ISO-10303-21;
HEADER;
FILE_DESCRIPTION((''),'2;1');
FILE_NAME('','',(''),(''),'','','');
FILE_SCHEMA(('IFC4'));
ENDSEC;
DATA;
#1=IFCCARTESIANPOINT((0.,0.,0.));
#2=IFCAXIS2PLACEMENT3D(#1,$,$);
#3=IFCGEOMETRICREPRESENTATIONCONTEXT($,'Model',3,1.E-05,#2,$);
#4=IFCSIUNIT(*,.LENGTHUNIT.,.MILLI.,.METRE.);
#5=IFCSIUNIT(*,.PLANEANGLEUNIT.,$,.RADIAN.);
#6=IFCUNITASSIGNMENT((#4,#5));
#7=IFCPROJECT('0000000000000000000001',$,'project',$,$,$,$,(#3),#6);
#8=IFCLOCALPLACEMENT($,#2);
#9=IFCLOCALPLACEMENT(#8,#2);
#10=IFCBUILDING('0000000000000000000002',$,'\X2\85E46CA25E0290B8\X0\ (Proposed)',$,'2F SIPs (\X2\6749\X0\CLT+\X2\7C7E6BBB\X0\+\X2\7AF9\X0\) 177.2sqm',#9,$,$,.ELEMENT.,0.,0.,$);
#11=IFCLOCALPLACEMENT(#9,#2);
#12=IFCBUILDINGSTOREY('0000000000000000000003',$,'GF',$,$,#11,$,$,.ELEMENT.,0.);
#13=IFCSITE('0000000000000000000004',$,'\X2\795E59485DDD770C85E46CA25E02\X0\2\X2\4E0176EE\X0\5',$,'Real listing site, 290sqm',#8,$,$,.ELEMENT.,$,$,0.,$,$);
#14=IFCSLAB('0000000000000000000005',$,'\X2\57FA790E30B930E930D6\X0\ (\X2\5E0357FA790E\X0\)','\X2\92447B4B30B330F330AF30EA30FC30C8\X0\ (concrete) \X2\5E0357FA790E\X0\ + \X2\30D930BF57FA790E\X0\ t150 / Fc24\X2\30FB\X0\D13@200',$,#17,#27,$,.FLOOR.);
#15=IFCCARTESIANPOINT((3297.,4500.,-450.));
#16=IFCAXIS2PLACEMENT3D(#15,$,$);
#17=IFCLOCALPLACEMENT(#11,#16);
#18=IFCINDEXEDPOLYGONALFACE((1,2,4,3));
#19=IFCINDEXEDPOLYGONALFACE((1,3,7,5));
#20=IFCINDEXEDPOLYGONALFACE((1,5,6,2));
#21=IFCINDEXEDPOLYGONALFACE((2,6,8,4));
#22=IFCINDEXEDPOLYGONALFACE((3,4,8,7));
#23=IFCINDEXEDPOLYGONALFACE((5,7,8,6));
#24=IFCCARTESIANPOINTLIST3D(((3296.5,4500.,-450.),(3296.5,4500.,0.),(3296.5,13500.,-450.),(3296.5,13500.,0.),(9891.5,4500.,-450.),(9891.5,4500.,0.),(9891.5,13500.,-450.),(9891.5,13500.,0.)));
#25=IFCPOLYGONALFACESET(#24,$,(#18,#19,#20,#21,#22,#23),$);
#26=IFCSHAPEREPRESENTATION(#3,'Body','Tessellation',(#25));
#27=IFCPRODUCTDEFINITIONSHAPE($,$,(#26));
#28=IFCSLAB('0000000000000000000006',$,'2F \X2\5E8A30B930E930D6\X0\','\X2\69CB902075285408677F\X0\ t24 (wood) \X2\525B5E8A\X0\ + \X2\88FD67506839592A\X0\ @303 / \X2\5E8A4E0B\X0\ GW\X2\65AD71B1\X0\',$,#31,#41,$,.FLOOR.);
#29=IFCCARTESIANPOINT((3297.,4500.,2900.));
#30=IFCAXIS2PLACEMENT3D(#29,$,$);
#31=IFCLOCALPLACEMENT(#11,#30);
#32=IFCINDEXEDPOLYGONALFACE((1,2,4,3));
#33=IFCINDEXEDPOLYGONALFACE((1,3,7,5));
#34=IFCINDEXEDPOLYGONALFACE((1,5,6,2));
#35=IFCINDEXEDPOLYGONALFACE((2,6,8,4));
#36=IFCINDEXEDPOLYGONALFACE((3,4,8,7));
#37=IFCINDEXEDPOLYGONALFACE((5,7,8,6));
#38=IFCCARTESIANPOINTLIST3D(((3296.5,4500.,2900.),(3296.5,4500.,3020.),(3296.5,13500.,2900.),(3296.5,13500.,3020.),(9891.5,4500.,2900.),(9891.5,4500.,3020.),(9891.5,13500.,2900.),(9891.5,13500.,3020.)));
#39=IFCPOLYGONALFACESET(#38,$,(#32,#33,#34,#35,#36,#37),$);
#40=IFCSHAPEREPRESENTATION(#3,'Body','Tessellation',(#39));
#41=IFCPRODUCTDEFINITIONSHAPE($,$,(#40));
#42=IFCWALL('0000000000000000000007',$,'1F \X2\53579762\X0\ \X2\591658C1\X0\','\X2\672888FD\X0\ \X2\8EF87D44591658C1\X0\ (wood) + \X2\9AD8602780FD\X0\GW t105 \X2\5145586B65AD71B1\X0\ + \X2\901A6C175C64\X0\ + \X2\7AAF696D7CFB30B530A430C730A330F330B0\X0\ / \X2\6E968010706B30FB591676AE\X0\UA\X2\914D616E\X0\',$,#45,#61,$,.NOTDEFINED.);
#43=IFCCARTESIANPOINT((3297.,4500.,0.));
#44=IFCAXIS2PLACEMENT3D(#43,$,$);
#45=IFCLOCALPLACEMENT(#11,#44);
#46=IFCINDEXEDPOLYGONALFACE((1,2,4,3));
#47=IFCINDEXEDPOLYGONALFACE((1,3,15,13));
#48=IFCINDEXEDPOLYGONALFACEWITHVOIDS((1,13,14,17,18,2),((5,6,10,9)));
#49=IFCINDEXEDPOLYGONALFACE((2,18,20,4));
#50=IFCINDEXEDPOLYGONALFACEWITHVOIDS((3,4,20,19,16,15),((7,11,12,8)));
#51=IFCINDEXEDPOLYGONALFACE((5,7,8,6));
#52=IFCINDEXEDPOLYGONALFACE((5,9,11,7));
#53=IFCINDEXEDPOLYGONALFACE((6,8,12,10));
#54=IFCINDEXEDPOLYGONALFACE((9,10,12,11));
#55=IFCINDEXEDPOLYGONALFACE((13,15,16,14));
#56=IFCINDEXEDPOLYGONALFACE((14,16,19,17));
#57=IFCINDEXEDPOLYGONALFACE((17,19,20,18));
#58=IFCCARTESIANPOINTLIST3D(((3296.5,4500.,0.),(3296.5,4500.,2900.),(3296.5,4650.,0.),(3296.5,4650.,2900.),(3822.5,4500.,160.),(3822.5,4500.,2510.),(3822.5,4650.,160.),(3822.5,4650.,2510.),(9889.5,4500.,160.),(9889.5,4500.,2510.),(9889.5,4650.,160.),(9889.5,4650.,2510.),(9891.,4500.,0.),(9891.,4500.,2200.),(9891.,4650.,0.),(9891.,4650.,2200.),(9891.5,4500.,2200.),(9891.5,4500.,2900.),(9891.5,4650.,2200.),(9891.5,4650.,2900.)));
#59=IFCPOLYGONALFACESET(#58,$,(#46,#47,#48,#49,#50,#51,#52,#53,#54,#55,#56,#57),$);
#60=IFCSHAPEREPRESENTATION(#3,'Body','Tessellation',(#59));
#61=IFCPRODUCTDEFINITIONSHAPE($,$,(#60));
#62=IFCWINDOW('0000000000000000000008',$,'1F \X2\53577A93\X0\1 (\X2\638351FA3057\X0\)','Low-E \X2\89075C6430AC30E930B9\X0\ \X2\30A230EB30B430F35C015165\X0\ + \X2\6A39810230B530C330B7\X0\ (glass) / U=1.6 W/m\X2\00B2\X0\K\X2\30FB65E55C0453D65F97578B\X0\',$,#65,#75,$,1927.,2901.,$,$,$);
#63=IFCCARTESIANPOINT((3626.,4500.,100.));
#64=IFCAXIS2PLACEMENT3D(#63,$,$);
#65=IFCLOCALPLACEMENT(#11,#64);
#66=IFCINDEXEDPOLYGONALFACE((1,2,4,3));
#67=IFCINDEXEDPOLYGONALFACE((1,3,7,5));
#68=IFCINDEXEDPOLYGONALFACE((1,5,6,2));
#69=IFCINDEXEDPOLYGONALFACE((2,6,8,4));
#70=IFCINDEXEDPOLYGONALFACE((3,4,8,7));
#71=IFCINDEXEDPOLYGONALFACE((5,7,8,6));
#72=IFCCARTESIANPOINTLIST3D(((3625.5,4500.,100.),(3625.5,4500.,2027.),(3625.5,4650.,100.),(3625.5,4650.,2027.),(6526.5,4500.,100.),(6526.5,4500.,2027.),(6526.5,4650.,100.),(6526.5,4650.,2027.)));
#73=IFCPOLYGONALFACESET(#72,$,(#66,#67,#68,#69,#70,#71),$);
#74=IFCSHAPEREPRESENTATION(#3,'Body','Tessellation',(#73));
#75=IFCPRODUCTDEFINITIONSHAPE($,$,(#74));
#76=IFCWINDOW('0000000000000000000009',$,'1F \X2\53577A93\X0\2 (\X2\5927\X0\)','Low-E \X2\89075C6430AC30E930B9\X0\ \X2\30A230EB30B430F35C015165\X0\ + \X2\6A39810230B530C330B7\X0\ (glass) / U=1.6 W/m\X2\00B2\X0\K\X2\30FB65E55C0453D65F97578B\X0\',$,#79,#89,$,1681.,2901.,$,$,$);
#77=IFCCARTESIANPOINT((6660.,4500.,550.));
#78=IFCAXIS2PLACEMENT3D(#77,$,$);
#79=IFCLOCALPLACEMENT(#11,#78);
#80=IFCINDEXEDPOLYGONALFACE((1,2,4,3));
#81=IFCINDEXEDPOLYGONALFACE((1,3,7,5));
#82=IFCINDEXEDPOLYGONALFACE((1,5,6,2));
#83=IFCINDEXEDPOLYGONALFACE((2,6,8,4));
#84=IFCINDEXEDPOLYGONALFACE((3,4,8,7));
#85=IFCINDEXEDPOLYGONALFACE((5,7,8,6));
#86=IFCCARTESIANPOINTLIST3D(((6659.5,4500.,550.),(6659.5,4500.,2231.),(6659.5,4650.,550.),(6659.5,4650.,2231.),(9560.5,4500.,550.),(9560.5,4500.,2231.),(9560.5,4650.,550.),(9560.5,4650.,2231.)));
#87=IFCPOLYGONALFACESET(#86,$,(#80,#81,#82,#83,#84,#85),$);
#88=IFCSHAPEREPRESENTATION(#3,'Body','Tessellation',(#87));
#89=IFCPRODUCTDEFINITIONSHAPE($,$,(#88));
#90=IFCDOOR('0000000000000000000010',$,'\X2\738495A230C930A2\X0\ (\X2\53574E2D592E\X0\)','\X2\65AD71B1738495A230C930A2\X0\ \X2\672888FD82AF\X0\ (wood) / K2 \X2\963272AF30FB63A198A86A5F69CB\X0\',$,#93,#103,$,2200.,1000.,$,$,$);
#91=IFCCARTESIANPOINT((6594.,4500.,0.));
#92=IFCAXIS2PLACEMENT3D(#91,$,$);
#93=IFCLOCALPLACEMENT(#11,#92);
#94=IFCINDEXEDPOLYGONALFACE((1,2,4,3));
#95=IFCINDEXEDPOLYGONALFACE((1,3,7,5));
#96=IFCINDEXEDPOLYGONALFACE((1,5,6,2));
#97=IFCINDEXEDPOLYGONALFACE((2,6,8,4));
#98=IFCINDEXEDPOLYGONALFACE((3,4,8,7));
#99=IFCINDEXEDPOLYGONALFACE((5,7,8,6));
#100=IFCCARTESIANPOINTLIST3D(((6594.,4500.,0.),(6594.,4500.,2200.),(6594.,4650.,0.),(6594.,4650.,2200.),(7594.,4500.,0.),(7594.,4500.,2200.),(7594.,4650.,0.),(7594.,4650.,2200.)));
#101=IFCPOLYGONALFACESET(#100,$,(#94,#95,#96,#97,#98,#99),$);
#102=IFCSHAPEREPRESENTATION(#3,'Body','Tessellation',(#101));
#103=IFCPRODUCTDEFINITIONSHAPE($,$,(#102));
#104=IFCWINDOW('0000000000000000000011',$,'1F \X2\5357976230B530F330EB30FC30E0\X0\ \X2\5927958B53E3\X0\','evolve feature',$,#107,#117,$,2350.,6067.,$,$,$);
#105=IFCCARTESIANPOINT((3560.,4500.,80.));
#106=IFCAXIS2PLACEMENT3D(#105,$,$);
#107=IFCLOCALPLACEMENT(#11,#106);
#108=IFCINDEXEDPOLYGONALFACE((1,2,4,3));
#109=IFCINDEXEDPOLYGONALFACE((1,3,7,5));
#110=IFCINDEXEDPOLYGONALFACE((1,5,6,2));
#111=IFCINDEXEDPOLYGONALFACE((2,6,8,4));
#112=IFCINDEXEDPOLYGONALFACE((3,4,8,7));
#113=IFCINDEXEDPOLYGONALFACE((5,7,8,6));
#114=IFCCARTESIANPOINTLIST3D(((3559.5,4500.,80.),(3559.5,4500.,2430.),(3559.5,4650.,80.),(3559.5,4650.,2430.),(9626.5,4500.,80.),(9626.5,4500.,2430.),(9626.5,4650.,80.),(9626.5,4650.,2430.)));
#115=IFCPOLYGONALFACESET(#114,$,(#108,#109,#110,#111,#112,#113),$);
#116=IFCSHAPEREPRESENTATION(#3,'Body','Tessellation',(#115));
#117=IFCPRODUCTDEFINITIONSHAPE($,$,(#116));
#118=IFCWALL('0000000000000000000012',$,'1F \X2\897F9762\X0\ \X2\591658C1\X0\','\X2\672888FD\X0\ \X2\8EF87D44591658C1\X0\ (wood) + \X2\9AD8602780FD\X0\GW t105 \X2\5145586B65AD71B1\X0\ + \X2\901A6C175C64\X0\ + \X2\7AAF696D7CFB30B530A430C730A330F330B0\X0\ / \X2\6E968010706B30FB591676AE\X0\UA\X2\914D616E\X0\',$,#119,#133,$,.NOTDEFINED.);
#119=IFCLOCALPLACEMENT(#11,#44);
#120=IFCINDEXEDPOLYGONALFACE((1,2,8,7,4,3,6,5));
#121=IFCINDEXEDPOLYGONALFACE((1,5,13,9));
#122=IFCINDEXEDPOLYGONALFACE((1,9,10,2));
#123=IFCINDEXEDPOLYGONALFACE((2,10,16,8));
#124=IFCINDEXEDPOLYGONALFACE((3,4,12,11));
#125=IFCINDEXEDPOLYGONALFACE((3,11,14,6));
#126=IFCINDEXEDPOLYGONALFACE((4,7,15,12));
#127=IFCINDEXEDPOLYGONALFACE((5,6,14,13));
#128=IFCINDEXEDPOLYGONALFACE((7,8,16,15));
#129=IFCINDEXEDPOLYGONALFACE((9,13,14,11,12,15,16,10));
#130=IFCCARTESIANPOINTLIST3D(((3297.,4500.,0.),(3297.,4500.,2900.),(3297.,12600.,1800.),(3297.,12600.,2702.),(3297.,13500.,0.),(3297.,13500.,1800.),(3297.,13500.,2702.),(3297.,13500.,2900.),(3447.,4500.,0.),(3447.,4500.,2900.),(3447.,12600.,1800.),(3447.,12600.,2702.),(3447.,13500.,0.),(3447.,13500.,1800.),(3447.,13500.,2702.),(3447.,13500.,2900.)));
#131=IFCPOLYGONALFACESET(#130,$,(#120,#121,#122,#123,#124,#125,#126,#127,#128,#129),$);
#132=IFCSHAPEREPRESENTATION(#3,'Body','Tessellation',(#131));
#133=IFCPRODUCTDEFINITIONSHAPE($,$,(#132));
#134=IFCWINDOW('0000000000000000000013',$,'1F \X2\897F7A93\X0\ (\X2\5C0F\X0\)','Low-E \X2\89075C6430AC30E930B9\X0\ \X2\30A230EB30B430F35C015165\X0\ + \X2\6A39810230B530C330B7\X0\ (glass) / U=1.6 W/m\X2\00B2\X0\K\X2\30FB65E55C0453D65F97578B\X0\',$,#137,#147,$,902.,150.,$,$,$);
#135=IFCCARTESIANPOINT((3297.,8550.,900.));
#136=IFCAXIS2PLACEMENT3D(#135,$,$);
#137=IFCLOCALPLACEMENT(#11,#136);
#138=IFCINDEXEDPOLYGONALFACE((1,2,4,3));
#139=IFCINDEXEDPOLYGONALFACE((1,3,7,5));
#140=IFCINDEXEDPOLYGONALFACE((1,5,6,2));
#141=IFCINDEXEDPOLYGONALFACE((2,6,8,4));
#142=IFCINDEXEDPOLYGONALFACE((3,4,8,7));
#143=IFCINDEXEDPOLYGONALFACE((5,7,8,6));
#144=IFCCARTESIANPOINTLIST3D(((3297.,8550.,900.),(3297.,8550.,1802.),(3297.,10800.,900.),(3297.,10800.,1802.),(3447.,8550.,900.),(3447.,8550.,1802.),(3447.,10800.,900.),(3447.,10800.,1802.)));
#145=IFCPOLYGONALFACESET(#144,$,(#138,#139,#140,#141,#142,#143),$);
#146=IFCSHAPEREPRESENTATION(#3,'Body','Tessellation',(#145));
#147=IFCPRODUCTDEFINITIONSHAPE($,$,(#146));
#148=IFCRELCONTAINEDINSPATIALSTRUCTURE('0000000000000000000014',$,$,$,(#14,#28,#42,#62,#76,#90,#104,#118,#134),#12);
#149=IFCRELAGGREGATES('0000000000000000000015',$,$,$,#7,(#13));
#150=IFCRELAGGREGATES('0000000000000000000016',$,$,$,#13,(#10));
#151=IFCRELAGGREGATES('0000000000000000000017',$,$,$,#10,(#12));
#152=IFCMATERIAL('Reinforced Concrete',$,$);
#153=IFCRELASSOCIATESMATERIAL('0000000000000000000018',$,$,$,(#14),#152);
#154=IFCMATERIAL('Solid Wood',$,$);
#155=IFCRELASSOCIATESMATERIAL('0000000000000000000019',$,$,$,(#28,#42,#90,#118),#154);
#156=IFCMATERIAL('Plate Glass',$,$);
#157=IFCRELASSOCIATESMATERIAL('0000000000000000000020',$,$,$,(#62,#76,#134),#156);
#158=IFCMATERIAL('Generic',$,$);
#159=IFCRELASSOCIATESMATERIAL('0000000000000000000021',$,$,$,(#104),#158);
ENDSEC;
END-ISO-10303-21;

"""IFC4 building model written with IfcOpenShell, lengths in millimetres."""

from ifc_helpers import new_model, si_unit, frame, frame_2d, origin, place, context, project, spatial, rectangle, extrude, material, element, fill, save


model = new_model("IFC4")

# Units and contexts
model_context = context("Model", 3, precision=1e-05, world=origin())
ifc_project = project(units=[si_unit("LENGTHUNIT", "METRE", prefix="MILLI"), si_unit("PLANEANGLEUNIT", "RADIAN")], contexts=[model_context])

# Site, building, storey
site_placement = place(None, origin())
site = spatial("IfcSite", under=ifc_project, at=site_placement, Name="神奈川県藤沢市2丁目5", ObjectType="Real listing site, 290sqm", CompositionType="ELEMENT", RefElevation=0.0)
building_placement = place(site_placement, origin())
building = spatial("IfcBuilding", under=site, at=building_placement, Name="藤沢市邸 (Proposed)", ObjectType="2F SIPs (杉CLT+籾殻+竹) 177.2sqm", CompositionType="ELEMENT", ElevationOfRefHeight=0.0, ElevationOfTerrain=0.0)
storey_placement = place(building_placement, origin())
storey = spatial("IfcBuildingStorey", under=building, at=storey_placement, Name="GF", CompositionType="ELEMENT", Elevation=0.0)

# Slabs
ifc_material_1 = material(Name="Reinforced Concrete")
slab_1_placement = place(storey_placement, frame((3297.0, 4500.0, -450.0)))
element("IfcSlab", 1, at=slab_1_placement, inside=storey, material=ifc_material_1, Name="基礎スラブ (布基礎)", Description="鉄筋コンクリート (concrete) 布基礎 + ベタ基礎 t150 / Fc24・D13@200", PredefinedType="FLOOR", context=model_context, shape_type="SweptSolid", body=[
    extrude(rectangle(XDim=6595.0, YDim=9000.0, at=frame_2d((3297.0, 4500.0))), frame((3297.0, 4500.0, -450.0)), (0.0, 0.0, 1.0), 450.0),
])
ifc_material_2 = material(Name="Solid Wood")
slab_2_placement = place(storey_placement, frame((3297.0, 4500.0, 2900.0)))
element("IfcSlab", 2, at=slab_2_placement, inside=storey, material=ifc_material_2, Name="2F 床スラブ", Description="構造用合板 t24 (wood) 剛床 + 製材根太 @303 / 床下 GW断熱", PredefinedType="FLOOR", context=model_context, shape_type="SweptSolid", body=[
    extrude(rectangle(XDim=6595.0, YDim=9000.0, at=frame_2d((3297.0, 4500.0))), frame((3297.0, 4500.0, 2900.0)), (0.0, 0.0, 1.0), 120.0),
])

# Wall, openings, windows, door
wall_1_placement = place(storey_placement, frame((3297.0, 4500.0, 0.0)))
wall_1 = element("IfcWall", 3, at=wall_1_placement, inside=storey, material=ifc_material_2, Name="1F 南面 外壁", Description="木製 軸組外壁 (wood) + 高性能GW t105 充填断熱 + 通気層 + 窯業系サイディング / 準耐火・外皮UA配慮", PredefinedType="NOTDEFINED", context=model_context, shape_type="SweptSolid", body=[
    extrude(rectangle(XDim=6595.0, YDim=150.0, at=frame_2d((3297.0, 75.0))), frame((3297.0, 4500.0, 0.0)), (0.0, 0.0, 1.0), 2900.0),
])
opening_1_placement = place(storey_placement, frame((3626.0, 4500.0, 100.0)))
opening_1 = element("IfcOpeningElement", 4, at=opening_1_placement, cuts=wall_1, PredefinedType="NOTDEFINED", context=model_context, shape_type="SweptSolid", body=[
    extrude(rectangle(XDim=2901.0, YDim=150.0, at=frame_2d((1450.0, 75.0))), frame((3626.0, 4500.0, 100.0)), (0.0, 0.0, 1.0), 1927.0),
])
opening_2_placement = place(storey_placement, frame((6660.0, 4500.0, 550.0)))
opening_2 = element("IfcOpeningElement", 5, at=opening_2_placement, cuts=wall_1, PredefinedType="NOTDEFINED", context=model_context, shape_type="SweptSolid", body=[
    extrude(rectangle(XDim=2901.0, YDim=150.0, at=frame_2d((1450.0, 75.0))), frame((6660.0, 4500.0, 550.0)), (0.0, 0.0, 1.0), 1681.0),
])
opening_3_placement = place(storey_placement, frame((6594.0, 4500.0, 0.0)))
opening_3 = element("IfcOpeningElement", 6, at=opening_3_placement, cuts=wall_1, PredefinedType="NOTDEFINED", context=model_context, shape_type="SweptSolid", body=[
    extrude(rectangle(XDim=1000.0, YDim=150.0, at=frame_2d((500.0, 75.0))), frame((6594.0, 4500.0, 0.0)), (0.0, 0.0, 1.0), 2200.0),
])
opening_4_placement = place(storey_placement, frame((3560.0, 4500.0, 80.0)))
opening_4 = element("IfcOpeningElement", 7, at=opening_4_placement, cuts=wall_1, PredefinedType="NOTDEFINED", context=model_context, shape_type="SweptSolid", body=[
    extrude(rectangle(XDim=6067.0, YDim=150.0, at=frame_2d((3033.0, 75.0))), frame((3560.0, 4500.0, 80.0)), (0.0, 0.0, 1.0), 2350.0),
])
ifc_material_3 = material(Name="Plate Glass")
window_1_placement = place(storey_placement, frame((3626.0, 4500.0, 100.0)))
window_1 = element("IfcWindow", 8, at=window_1_placement, inside=storey, material=ifc_material_3, Name="1F 南窓1 (掃出し)", Description="Low-E 複層ガラス アルゴン封入 + 樹脂サッシ (glass) / U=1.6 W/m²K・日射取得型", OverallHeight=1927.0, OverallWidth=2901.0, context=model_context, shape_type="SweptSolid", body=[
    extrude(rectangle(XDim=2901.0, YDim=150.0, at=frame_2d((1450.0, 75.0))), frame((3626.0, 4500.0, 100.0)), (0.0, 0.0, 1.0), 1927.0),
])
fill(opening_1, window_1)
window_2_placement = place(storey_placement, frame((6660.0, 4500.0, 550.0)))
window_2 = element("IfcWindow", 9, at=window_2_placement, inside=storey, material=ifc_material_3, Name="1F 南窓2 (大)", Description="Low-E 複層ガラス アルゴン封入 + 樹脂サッシ (glass) / U=1.6 W/m²K・日射取得型", OverallHeight=1681.0, OverallWidth=2901.0, context=model_context, shape_type="SweptSolid", body=[
    extrude(rectangle(XDim=2901.0, YDim=150.0, at=frame_2d((1450.0, 75.0))), frame((6660.0, 4500.0, 550.0)), (0.0, 0.0, 1.0), 1681.0),
])
fill(opening_2, window_2)
door_placement = place(storey_placement, frame((6594.0, 4500.0, 0.0)))
door = element("IfcDoor", 10, at=door_placement, inside=storey, material=ifc_material_2, Name="玄関ドア (南中央)", Description="断熱玄関ドア 木製芯 (wood) / K2 防犯・採風機構", OverallHeight=2200.0, OverallWidth=1000.0, context=model_context, shape_type="SweptSolid", body=[
    extrude(rectangle(XDim=1000.0, YDim=150.0, at=frame_2d((500.0, 75.0))), frame((6594.0, 4500.0, 0.0)), (0.0, 0.0, 1.0), 2200.0),
])
fill(opening_3, door)
ifc_material_4 = material(Name="Generic")
window_3_placement = place(storey_placement, frame((3560.0, 4500.0, 80.0)))
window_3 = element("IfcWindow", 11, at=window_3_placement, inside=storey, material=ifc_material_4, Name="1F 南面サンルーム 大開口", Description="evolve feature", OverallHeight=2350.0, OverallWidth=6067.0, context=model_context, shape_type="SweptSolid", body=[
    extrude(rectangle(XDim=6067.0, YDim=150.0, at=frame_2d((3033.0, 75.0))), frame((3560.0, 4500.0, 80.0)), (0.0, 0.0, 1.0), 2350.0),
])
fill(opening_4, window_3)

# Wall, opening, window
wall_2_placement = place(storey_placement, frame((3297.0, 4500.0, 0.0)))
wall_2 = element("IfcWall", 12, at=wall_2_placement, inside=storey, material=ifc_material_2, Name="1F 西面 外壁", Description="木製 軸組外壁 (wood) + 高性能GW t105 充填断熱 + 通気層 + 窯業系サイディング / 準耐火・外皮UA配慮", PredefinedType="NOTDEFINED", context=model_context, shape_type="SweptSolid", body=[
    extrude(rectangle(XDim=150.0, YDim=9000.0, at=frame_2d((75.0, 4500.0))), frame((3297.0, 4500.0, 0.0)), (0.0, 0.0, 1.0), 2900.0),
])
opening_5_placement = place(storey_placement, frame((3297.0, 8550.0, 900.0)))
opening_5 = element("IfcOpeningElement", 13, at=opening_5_placement, cuts=wall_2, PredefinedType="NOTDEFINED", context=model_context, shape_type="SweptSolid", body=[
    extrude(rectangle(XDim=150.0, YDim=2250.0, at=frame_2d((75.0, 1125.0))), frame((3297.0, 8550.0, 900.0)), (0.0, 0.0, 1.0), 902.0),
])
window_4_placement = place(storey_placement, frame((3297.0, 8550.0, 900.0)))
window_4 = element("IfcWindow", 14, at=window_4_placement, inside=storey, material=ifc_material_3, Name="1F 西窓 (小)", Description="Low-E 複層ガラス アルゴン封入 + 樹脂サッシ (glass) / U=1.6 W/m²K・日射取得型", OverallHeight=902.0, OverallWidth=150.0, context=model_context, shape_type="SweptSolid", body=[
    extrude(rectangle(XDim=150.0, YDim=2250.0, at=frame_2d((75.0, 1125.0))), frame((3297.0, 8550.0, 900.0)), (0.0, 0.0, 1.0), 902.0),
])
fill(opening_5, window_4)

save(model, "model.ifc")
